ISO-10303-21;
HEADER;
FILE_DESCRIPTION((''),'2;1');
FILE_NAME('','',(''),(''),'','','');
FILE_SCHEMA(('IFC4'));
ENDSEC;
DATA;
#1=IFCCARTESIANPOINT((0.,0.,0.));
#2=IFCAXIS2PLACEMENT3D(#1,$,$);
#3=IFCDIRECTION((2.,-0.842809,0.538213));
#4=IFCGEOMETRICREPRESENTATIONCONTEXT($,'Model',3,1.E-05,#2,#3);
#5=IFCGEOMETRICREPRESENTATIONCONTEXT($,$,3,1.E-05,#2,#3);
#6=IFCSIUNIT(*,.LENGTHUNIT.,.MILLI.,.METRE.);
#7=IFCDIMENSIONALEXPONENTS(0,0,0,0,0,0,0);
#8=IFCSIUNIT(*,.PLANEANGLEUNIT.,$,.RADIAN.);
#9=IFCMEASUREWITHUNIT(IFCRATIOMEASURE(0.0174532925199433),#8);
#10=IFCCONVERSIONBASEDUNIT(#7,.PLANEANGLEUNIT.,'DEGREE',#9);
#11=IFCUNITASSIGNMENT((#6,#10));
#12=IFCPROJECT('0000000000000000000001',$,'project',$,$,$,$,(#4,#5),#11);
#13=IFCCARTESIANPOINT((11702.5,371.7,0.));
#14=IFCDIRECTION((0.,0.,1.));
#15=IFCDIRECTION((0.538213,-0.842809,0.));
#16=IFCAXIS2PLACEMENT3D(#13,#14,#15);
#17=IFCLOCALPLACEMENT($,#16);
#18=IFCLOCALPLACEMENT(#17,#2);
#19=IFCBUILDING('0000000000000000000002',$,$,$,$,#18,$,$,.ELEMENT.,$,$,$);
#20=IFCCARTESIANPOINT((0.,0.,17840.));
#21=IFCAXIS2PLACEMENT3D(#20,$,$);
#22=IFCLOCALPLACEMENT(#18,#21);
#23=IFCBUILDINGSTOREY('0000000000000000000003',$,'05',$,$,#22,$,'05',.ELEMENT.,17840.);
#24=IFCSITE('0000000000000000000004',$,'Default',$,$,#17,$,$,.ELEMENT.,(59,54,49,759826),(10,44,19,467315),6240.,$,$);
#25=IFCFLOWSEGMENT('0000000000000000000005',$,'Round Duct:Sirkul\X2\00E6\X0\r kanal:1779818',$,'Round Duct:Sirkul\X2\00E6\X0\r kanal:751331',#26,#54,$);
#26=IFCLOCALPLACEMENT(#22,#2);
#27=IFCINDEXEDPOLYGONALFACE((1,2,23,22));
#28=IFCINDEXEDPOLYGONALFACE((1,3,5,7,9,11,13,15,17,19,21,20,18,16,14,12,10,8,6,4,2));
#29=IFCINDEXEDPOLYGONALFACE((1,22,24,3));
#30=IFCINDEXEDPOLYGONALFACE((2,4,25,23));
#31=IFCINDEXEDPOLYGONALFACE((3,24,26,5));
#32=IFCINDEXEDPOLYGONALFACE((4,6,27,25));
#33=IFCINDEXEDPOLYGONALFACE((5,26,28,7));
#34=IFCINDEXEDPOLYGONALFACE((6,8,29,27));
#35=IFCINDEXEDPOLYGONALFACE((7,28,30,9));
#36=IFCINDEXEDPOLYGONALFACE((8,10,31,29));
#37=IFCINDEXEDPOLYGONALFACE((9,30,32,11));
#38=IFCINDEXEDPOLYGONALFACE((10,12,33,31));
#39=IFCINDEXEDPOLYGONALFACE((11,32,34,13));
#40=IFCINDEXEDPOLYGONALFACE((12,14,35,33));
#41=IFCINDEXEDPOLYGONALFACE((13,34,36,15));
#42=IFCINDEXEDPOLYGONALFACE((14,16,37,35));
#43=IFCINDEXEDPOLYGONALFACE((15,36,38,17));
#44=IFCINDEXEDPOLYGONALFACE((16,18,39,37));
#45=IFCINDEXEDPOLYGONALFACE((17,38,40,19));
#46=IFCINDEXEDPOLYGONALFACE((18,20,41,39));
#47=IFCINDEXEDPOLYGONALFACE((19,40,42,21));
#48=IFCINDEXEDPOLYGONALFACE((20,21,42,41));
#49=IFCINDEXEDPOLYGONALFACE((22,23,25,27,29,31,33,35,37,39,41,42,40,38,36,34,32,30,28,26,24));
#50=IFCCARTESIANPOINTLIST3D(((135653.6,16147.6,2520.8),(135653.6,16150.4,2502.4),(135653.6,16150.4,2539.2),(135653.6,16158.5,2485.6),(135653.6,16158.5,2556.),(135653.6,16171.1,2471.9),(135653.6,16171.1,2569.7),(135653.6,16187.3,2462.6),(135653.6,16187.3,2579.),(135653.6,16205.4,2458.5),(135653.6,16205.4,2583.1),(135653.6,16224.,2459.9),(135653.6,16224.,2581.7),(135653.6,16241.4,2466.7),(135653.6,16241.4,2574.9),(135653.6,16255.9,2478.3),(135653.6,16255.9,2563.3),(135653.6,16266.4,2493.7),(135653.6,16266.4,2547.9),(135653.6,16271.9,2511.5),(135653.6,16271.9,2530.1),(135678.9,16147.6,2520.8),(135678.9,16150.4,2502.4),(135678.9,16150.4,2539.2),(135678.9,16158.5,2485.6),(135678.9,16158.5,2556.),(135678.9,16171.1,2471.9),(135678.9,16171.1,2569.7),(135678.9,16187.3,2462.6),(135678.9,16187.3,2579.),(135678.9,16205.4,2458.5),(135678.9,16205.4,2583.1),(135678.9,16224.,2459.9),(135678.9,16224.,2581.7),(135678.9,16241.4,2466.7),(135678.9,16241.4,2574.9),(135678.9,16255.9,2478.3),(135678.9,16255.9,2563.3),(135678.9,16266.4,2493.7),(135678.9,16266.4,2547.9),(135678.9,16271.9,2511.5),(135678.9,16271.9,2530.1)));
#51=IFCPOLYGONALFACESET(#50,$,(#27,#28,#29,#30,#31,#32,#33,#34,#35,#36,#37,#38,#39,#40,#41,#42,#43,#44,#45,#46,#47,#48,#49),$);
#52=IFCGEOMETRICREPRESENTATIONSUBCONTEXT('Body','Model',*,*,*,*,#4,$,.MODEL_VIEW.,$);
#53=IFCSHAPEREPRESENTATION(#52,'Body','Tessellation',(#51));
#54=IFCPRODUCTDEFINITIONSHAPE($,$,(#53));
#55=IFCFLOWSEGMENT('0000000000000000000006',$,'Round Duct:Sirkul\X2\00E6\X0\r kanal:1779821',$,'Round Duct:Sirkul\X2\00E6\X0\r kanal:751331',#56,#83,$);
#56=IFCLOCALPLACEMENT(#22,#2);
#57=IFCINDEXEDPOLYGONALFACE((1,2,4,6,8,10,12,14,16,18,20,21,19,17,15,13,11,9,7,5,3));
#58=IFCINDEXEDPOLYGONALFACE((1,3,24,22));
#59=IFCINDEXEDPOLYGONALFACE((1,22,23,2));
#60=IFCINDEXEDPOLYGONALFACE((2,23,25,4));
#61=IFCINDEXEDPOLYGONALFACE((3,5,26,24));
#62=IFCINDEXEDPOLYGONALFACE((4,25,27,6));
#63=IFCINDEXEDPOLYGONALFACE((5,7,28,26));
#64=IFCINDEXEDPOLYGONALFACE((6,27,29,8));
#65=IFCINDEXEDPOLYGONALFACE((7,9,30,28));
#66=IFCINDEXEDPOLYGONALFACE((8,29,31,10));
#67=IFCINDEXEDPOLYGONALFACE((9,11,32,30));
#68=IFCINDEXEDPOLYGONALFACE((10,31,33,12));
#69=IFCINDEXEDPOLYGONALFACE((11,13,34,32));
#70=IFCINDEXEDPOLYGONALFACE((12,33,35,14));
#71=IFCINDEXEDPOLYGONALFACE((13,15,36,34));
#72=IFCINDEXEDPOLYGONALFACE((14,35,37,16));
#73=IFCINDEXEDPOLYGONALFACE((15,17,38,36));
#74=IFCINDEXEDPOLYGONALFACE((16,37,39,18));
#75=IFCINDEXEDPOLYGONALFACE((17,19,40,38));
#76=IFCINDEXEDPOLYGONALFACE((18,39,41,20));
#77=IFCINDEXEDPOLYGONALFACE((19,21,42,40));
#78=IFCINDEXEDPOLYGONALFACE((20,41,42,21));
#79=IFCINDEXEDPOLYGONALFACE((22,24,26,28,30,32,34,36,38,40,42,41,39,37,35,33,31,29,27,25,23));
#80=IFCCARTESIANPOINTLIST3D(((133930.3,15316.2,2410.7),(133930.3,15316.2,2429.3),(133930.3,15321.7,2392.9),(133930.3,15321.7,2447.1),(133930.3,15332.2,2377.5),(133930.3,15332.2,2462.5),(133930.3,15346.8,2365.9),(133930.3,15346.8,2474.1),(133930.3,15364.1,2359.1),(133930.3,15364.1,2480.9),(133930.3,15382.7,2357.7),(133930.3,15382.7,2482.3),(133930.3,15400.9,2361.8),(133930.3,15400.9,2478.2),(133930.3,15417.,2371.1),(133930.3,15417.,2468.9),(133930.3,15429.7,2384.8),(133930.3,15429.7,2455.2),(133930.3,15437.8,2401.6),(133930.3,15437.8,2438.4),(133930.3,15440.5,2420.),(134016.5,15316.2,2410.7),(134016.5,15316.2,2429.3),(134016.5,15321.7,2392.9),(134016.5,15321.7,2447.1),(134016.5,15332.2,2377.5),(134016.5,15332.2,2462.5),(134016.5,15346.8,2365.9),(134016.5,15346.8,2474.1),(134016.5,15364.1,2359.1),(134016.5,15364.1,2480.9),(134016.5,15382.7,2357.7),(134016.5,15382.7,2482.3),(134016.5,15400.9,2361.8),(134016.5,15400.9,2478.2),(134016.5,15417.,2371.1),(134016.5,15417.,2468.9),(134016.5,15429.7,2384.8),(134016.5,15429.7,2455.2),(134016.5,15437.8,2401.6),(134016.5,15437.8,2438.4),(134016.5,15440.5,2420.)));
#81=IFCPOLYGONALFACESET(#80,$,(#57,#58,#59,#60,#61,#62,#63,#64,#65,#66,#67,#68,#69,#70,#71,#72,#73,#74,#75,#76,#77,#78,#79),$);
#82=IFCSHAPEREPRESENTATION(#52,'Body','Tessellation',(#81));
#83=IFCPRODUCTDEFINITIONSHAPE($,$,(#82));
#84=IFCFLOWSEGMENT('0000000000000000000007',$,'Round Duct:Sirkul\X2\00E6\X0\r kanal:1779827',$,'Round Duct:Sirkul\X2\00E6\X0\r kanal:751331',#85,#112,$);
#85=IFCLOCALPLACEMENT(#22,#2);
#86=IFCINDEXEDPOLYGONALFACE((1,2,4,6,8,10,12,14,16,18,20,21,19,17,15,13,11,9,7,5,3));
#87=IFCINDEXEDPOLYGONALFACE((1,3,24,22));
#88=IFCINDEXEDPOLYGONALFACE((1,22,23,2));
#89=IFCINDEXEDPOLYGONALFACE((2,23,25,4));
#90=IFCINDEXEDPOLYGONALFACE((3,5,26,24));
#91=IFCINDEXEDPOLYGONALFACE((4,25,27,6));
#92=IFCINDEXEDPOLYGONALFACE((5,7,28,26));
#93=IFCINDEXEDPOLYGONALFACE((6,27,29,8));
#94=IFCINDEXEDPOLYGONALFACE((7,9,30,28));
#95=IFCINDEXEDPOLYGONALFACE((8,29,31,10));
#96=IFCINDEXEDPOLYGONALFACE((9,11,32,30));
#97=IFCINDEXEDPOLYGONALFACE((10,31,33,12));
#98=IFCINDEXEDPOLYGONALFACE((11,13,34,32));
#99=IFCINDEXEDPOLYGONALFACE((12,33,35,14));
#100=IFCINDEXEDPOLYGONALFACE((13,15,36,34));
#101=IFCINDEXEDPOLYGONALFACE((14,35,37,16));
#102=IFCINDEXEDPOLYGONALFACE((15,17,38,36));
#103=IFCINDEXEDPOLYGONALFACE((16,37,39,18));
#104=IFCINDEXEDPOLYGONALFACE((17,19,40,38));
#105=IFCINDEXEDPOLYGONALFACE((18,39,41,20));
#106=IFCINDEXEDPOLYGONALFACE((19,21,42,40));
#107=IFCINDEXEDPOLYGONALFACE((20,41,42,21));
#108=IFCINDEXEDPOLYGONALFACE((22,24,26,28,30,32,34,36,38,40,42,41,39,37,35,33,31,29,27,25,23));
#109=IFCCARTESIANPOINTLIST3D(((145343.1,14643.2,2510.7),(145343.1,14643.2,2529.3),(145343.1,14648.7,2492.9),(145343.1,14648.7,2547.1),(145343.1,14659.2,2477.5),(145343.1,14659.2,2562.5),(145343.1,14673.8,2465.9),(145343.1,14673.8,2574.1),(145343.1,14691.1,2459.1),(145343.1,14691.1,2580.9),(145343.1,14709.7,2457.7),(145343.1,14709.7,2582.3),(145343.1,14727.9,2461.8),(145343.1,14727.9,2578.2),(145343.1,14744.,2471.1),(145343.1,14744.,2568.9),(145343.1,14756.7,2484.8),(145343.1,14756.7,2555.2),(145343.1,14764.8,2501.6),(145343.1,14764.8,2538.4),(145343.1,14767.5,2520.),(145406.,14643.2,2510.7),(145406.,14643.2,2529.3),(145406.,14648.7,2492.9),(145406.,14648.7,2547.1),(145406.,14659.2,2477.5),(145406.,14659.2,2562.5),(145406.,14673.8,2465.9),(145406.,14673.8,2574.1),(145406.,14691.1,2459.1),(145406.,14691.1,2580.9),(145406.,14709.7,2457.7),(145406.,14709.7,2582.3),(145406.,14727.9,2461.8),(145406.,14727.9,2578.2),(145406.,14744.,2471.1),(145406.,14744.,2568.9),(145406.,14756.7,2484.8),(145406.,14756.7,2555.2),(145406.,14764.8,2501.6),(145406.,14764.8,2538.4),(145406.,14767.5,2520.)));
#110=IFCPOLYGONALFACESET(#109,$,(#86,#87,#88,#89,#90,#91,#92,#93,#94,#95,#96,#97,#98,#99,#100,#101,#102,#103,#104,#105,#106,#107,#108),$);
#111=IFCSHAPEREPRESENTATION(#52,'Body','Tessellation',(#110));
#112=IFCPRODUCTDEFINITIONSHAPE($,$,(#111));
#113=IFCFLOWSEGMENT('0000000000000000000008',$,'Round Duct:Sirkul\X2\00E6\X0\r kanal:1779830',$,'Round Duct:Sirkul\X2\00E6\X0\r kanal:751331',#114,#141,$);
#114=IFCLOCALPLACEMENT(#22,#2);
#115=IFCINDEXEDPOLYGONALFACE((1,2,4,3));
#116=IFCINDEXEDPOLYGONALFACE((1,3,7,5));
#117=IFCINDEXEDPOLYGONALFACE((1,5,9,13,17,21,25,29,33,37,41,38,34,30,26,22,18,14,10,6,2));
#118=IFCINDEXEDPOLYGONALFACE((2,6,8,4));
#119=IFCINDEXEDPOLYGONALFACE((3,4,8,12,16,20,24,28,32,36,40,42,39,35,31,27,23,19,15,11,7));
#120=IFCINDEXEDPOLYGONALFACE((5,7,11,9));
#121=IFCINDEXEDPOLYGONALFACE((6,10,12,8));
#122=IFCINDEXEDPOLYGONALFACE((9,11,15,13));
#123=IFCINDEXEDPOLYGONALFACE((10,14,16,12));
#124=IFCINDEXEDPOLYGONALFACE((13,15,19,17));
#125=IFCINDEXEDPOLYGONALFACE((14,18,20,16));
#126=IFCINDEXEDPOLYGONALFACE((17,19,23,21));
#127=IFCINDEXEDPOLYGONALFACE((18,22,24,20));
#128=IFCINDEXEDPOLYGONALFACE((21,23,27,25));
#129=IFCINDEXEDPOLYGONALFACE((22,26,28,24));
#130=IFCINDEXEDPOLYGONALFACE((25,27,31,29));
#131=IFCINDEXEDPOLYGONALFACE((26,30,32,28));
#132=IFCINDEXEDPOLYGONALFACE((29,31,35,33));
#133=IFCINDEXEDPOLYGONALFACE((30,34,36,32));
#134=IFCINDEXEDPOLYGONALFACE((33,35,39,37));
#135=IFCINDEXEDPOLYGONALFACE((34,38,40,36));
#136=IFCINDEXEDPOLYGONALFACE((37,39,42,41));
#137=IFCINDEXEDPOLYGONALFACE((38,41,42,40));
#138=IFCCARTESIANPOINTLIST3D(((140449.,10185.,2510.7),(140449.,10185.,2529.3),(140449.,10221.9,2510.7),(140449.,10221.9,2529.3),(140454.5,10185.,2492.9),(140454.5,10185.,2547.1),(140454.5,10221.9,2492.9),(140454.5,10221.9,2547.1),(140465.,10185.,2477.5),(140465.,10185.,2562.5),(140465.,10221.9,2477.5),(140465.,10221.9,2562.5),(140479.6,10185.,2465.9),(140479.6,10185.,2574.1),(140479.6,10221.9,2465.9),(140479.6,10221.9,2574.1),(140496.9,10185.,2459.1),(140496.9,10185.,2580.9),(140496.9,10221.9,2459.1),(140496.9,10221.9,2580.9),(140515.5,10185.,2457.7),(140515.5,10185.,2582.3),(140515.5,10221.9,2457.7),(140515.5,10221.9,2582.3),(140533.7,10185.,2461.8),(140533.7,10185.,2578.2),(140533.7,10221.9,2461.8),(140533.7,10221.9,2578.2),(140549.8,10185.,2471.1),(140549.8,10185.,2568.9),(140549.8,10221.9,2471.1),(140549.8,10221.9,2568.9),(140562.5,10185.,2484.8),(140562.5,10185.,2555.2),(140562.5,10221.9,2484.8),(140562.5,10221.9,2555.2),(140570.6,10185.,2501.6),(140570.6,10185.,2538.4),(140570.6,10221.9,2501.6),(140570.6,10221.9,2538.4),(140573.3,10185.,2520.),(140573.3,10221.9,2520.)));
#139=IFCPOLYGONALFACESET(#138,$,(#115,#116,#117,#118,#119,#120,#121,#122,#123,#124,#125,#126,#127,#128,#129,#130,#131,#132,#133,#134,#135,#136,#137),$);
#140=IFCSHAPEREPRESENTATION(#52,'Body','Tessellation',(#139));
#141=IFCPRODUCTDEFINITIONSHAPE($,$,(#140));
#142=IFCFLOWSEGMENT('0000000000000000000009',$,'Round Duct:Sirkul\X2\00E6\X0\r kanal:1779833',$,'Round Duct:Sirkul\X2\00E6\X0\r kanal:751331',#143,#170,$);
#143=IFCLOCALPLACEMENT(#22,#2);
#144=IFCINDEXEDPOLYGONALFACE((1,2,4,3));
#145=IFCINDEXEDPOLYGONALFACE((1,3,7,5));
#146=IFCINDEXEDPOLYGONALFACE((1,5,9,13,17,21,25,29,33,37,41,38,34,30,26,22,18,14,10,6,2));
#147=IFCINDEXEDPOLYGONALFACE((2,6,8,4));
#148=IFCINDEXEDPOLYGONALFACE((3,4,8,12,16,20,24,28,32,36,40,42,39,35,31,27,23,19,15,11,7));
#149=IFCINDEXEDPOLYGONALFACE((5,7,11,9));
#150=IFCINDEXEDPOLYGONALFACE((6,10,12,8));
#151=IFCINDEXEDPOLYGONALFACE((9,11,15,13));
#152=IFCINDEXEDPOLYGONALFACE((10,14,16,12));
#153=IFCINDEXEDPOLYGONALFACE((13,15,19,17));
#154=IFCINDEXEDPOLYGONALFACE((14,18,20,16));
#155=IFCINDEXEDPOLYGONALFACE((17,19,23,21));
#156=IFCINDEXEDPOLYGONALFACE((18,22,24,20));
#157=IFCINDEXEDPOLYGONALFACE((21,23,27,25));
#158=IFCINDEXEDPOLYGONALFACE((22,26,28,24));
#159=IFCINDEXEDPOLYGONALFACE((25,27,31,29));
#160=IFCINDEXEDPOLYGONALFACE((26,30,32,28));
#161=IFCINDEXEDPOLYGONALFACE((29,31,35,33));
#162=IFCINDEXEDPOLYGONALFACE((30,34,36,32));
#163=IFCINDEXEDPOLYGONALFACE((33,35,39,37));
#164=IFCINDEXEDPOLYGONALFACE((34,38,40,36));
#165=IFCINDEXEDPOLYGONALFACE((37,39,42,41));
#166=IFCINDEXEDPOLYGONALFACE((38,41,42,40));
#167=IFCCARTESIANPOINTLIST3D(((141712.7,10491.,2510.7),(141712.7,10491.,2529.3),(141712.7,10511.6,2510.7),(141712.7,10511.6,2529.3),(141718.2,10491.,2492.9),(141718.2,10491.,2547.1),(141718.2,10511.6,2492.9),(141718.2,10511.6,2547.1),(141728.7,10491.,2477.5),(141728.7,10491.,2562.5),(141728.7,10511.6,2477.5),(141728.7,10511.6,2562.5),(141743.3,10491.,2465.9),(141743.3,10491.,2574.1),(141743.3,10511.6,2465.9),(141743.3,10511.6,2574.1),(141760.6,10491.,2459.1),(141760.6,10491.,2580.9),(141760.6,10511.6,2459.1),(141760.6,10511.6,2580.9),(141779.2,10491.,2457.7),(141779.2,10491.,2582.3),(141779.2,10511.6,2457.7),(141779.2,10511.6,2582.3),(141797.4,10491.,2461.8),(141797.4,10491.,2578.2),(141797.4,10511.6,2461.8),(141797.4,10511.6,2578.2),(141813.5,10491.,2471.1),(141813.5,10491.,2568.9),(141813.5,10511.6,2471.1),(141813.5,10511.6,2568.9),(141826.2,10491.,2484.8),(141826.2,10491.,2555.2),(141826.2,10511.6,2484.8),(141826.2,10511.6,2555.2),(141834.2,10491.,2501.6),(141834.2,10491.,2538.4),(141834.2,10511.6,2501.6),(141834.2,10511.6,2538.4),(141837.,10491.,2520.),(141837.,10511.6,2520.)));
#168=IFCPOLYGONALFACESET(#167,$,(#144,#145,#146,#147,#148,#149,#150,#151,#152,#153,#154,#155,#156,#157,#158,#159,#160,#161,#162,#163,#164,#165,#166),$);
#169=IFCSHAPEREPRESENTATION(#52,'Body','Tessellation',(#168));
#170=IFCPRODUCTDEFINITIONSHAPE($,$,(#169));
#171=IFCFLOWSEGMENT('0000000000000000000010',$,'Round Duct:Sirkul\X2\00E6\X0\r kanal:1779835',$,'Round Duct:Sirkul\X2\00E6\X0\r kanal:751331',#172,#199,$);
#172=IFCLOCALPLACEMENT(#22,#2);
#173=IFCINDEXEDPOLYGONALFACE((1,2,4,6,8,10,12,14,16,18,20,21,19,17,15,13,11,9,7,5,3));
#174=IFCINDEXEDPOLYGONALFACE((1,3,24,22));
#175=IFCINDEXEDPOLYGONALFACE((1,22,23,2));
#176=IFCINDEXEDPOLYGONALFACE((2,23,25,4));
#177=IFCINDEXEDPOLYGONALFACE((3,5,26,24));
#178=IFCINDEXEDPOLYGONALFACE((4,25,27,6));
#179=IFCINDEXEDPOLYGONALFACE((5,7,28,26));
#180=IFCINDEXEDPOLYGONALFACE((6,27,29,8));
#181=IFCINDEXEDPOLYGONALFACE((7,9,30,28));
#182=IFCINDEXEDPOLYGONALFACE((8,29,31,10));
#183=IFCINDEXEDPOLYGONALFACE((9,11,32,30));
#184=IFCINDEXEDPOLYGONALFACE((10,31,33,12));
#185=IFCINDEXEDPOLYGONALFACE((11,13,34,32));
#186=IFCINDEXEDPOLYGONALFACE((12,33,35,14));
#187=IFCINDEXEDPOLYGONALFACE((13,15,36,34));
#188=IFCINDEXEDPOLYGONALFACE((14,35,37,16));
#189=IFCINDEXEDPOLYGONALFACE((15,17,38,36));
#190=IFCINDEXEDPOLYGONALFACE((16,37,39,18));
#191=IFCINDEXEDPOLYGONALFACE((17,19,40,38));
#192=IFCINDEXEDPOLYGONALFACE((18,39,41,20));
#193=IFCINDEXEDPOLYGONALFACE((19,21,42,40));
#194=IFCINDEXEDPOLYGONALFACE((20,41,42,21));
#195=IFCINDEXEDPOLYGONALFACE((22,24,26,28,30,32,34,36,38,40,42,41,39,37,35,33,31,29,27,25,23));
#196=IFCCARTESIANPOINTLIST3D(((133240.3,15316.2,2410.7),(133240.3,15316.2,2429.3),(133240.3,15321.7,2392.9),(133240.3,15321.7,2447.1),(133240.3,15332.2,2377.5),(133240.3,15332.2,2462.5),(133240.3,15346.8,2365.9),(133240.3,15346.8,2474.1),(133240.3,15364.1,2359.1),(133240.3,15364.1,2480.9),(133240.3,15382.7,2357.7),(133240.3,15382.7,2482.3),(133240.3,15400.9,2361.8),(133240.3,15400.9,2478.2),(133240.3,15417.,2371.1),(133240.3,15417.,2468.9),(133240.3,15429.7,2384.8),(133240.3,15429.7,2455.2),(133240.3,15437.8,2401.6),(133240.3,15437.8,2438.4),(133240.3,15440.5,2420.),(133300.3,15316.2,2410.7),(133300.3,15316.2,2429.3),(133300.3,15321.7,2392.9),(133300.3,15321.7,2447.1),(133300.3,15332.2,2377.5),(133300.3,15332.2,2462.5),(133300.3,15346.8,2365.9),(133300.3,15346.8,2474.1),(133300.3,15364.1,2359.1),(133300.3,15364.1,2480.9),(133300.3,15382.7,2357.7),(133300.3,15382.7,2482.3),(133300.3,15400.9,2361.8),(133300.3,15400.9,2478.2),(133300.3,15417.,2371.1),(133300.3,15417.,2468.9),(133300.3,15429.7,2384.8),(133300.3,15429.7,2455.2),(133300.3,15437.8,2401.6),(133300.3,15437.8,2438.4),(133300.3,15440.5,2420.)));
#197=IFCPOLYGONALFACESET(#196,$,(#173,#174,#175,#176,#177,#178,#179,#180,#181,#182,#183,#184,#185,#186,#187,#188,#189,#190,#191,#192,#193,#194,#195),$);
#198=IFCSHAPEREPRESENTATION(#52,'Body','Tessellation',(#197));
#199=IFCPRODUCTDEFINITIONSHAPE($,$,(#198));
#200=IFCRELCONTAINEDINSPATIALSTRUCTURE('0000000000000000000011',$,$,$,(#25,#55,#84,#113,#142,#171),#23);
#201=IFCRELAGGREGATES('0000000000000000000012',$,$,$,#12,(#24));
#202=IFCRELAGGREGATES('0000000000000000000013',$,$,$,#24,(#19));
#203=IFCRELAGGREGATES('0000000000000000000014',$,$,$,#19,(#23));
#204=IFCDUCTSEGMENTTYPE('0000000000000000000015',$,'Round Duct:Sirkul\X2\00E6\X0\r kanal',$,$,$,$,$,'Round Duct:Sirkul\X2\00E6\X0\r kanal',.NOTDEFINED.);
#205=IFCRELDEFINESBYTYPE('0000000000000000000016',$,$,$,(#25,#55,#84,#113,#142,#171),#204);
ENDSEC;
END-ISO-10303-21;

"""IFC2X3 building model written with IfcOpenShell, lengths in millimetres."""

from ifc_helpers import new_model, entity, si_unit, converted_unit, direction, frame, frame_2d, origin, origin_2d_with_axis, place, context, subcontext, project, spatial, circle, extrude, type_object, element, save


model = new_model("IFC2X3")

# Units and contexts
model_context = context("Model", 3, precision=1e-05, world=origin(), true_north=direction((2.0, -0.842809, 0.538213)))
context_of_model = context(None, 3, precision=1e-05, world=origin(), true_north=direction((2.0, -0.842809, 0.538213)))
body_context = subcontext(model_context, "Body", "Model", "MODEL_VIEW")
ifc_project = project(units=[si_unit("LENGTHUNIT", "METRE", prefix="MILLI"), converted_unit("PLANEANGLEUNIT", "DEGREE", entity("IfcRatioMeasure", 0.0174532925199433), si_unit("PLANEANGLEUNIT", "RADIAN"), dimensions=[0, 0, 0, 0, 0, 0, 0])], contexts=[model_context, context_of_model])

# Site, building, storey
site_placement = place(None, frame((11702.5, 371.7, 0.0), z_axis=(0.0, 0.0, 1.0), x_axis=(0.538213, -0.842809, 0.0)))
site = spatial("IfcSite", under=ifc_project, at=site_placement, Name="Default", CompositionType="ELEMENT", RefLatitude=(59, 54, 49, 759826), RefLongitude=(10, 44, 19, 467315), RefElevation=6240.0)
building_placement = place(site_placement, origin())
building = spatial("IfcBuilding", under=site, at=building_placement, CompositionType="ELEMENT")
storey_placement = place(building_placement, frame((0.0, 0.0, 17840.0)))
storey = spatial("IfcBuildingStorey", under=building, at=storey_placement, Name="05", LongName="05", CompositionType="ELEMENT", Elevation=17840.0)

# Flow segments
duct_segment_type_1 = type_object("IfcDuctSegmentType", Name="Round Duct:Sirkulær kanal", ElementType="Round Duct:Sirkulær kanal", PredefinedType="NOTDEFINED")
flow_segment_1_placement = place(storey_placement, origin())
element("IfcFlowSegment", 1, at=flow_segment_1_placement, inside=storey, type_object=duct_segment_type_1, Name="Round Duct:Sirkulær kanal:1779818", ObjectType="Round Duct:Sirkulær kanal:751331", context=body_context, shape_type="SweptSolid", body=[
    extrude(circle(Radius=62.5, at=frame_2d((0.0, 0.0), x_axis=(1.0, 0.0))), frame((135653.6, 16210.1, 2520.8), z_axis=(1.0, 0.0, 0.0), x_axis=(0.0, -1.0, 0.0)), (0.0, 0.0, 1.0), 25.3),
])
flow_segment_2_placement = place(storey_placement, origin())
element("IfcFlowSegment", 2, at=flow_segment_2_placement, inside=storey, type_object=duct_segment_type_1, Name="Round Duct:Sirkulær kanal:1779821", ObjectType="Round Duct:Sirkulær kanal:751331", context=body_context, shape_type="SweptSolid", body=[
    extrude(circle(Radius=62.5, at=origin_2d_with_axis()), frame((133930.3, 15378.0, 2420.0), z_axis=(1.0, 0.0, 0.0), x_axis=(0.0, 1.0, 0.0)), (0.0, 0.0, 1.0), 86.2),
])
flow_segment_3_placement = place(storey_placement, origin())
element("IfcFlowSegment", 3, at=flow_segment_3_placement, inside=storey, type_object=duct_segment_type_1, Name="Round Duct:Sirkulær kanal:1779827", ObjectType="Round Duct:Sirkulær kanal:751331", context=body_context, shape_type="SweptSolid", body=[
    extrude(circle(Radius=62.5, at=origin_2d_with_axis()), frame((145343.1, 14705.0, 2520.0), z_axis=(1.0, 0.0, 0.0), x_axis=(0.0, 1.0, 0.0)), (0.0, 0.0, 1.0), 62.9),
])
flow_segment_4_placement = place(storey_placement, origin())
element("IfcFlowSegment", 4, at=flow_segment_4_placement, inside=storey, type_object=duct_segment_type_1, Name="Round Duct:Sirkulær kanal:1779830", ObjectType="Round Duct:Sirkulær kanal:751331", context=body_context, shape_type="SweptSolid", body=[
    extrude(circle(Radius=62.5, at=frame_2d((0.0, 0.0), x_axis=(1.0, 0.0))), frame((140510.8, 10185.0, 2520.0), z_axis=(0.0, 1.0, 0.0), x_axis=(1.0, 0.0, 0.0)), (0.0, 0.0, 1.0), 36.9),
])
flow_segment_5_placement = place(storey_placement, origin())
element("IfcFlowSegment", 5, at=flow_segment_5_placement, inside=storey, type_object=duct_segment_type_1, Name="Round Duct:Sirkulær kanal:1779833", ObjectType="Round Duct:Sirkulær kanal:751331", context=body_context, shape_type="SweptSolid", body=[
    extrude(circle(Radius=62.5, at=frame_2d((0.0, 0.0), x_axis=(1.0, 0.0))), frame((141774.5, 10491.0, 2520.0), z_axis=(0.0, 1.0, 0.0), x_axis=(1.0, 0.0, 0.0)), (0.0, 0.0, 1.0), 20.6),
])
flow_segment_6_placement = place(storey_placement, origin())
element("IfcFlowSegment", 6, at=flow_segment_6_placement, inside=storey, type_object=duct_segment_type_1, Name="Round Duct:Sirkulær kanal:1779835", ObjectType="Round Duct:Sirkulær kanal:751331", context=body_context, shape_type="SweptSolid", body=[
    extrude(circle(Radius=62.5, at=frame_2d((0.0, 0.0), x_axis=(1.0, 0.0))), frame((133240.3, 15378.0, 2420.0), z_axis=(1.0, 0.0, 0.0), x_axis=(0.0, 1.0, 0.0)), (0.0, 0.0, 1.0), 60.0),
])

save(model, "model.ifc")
